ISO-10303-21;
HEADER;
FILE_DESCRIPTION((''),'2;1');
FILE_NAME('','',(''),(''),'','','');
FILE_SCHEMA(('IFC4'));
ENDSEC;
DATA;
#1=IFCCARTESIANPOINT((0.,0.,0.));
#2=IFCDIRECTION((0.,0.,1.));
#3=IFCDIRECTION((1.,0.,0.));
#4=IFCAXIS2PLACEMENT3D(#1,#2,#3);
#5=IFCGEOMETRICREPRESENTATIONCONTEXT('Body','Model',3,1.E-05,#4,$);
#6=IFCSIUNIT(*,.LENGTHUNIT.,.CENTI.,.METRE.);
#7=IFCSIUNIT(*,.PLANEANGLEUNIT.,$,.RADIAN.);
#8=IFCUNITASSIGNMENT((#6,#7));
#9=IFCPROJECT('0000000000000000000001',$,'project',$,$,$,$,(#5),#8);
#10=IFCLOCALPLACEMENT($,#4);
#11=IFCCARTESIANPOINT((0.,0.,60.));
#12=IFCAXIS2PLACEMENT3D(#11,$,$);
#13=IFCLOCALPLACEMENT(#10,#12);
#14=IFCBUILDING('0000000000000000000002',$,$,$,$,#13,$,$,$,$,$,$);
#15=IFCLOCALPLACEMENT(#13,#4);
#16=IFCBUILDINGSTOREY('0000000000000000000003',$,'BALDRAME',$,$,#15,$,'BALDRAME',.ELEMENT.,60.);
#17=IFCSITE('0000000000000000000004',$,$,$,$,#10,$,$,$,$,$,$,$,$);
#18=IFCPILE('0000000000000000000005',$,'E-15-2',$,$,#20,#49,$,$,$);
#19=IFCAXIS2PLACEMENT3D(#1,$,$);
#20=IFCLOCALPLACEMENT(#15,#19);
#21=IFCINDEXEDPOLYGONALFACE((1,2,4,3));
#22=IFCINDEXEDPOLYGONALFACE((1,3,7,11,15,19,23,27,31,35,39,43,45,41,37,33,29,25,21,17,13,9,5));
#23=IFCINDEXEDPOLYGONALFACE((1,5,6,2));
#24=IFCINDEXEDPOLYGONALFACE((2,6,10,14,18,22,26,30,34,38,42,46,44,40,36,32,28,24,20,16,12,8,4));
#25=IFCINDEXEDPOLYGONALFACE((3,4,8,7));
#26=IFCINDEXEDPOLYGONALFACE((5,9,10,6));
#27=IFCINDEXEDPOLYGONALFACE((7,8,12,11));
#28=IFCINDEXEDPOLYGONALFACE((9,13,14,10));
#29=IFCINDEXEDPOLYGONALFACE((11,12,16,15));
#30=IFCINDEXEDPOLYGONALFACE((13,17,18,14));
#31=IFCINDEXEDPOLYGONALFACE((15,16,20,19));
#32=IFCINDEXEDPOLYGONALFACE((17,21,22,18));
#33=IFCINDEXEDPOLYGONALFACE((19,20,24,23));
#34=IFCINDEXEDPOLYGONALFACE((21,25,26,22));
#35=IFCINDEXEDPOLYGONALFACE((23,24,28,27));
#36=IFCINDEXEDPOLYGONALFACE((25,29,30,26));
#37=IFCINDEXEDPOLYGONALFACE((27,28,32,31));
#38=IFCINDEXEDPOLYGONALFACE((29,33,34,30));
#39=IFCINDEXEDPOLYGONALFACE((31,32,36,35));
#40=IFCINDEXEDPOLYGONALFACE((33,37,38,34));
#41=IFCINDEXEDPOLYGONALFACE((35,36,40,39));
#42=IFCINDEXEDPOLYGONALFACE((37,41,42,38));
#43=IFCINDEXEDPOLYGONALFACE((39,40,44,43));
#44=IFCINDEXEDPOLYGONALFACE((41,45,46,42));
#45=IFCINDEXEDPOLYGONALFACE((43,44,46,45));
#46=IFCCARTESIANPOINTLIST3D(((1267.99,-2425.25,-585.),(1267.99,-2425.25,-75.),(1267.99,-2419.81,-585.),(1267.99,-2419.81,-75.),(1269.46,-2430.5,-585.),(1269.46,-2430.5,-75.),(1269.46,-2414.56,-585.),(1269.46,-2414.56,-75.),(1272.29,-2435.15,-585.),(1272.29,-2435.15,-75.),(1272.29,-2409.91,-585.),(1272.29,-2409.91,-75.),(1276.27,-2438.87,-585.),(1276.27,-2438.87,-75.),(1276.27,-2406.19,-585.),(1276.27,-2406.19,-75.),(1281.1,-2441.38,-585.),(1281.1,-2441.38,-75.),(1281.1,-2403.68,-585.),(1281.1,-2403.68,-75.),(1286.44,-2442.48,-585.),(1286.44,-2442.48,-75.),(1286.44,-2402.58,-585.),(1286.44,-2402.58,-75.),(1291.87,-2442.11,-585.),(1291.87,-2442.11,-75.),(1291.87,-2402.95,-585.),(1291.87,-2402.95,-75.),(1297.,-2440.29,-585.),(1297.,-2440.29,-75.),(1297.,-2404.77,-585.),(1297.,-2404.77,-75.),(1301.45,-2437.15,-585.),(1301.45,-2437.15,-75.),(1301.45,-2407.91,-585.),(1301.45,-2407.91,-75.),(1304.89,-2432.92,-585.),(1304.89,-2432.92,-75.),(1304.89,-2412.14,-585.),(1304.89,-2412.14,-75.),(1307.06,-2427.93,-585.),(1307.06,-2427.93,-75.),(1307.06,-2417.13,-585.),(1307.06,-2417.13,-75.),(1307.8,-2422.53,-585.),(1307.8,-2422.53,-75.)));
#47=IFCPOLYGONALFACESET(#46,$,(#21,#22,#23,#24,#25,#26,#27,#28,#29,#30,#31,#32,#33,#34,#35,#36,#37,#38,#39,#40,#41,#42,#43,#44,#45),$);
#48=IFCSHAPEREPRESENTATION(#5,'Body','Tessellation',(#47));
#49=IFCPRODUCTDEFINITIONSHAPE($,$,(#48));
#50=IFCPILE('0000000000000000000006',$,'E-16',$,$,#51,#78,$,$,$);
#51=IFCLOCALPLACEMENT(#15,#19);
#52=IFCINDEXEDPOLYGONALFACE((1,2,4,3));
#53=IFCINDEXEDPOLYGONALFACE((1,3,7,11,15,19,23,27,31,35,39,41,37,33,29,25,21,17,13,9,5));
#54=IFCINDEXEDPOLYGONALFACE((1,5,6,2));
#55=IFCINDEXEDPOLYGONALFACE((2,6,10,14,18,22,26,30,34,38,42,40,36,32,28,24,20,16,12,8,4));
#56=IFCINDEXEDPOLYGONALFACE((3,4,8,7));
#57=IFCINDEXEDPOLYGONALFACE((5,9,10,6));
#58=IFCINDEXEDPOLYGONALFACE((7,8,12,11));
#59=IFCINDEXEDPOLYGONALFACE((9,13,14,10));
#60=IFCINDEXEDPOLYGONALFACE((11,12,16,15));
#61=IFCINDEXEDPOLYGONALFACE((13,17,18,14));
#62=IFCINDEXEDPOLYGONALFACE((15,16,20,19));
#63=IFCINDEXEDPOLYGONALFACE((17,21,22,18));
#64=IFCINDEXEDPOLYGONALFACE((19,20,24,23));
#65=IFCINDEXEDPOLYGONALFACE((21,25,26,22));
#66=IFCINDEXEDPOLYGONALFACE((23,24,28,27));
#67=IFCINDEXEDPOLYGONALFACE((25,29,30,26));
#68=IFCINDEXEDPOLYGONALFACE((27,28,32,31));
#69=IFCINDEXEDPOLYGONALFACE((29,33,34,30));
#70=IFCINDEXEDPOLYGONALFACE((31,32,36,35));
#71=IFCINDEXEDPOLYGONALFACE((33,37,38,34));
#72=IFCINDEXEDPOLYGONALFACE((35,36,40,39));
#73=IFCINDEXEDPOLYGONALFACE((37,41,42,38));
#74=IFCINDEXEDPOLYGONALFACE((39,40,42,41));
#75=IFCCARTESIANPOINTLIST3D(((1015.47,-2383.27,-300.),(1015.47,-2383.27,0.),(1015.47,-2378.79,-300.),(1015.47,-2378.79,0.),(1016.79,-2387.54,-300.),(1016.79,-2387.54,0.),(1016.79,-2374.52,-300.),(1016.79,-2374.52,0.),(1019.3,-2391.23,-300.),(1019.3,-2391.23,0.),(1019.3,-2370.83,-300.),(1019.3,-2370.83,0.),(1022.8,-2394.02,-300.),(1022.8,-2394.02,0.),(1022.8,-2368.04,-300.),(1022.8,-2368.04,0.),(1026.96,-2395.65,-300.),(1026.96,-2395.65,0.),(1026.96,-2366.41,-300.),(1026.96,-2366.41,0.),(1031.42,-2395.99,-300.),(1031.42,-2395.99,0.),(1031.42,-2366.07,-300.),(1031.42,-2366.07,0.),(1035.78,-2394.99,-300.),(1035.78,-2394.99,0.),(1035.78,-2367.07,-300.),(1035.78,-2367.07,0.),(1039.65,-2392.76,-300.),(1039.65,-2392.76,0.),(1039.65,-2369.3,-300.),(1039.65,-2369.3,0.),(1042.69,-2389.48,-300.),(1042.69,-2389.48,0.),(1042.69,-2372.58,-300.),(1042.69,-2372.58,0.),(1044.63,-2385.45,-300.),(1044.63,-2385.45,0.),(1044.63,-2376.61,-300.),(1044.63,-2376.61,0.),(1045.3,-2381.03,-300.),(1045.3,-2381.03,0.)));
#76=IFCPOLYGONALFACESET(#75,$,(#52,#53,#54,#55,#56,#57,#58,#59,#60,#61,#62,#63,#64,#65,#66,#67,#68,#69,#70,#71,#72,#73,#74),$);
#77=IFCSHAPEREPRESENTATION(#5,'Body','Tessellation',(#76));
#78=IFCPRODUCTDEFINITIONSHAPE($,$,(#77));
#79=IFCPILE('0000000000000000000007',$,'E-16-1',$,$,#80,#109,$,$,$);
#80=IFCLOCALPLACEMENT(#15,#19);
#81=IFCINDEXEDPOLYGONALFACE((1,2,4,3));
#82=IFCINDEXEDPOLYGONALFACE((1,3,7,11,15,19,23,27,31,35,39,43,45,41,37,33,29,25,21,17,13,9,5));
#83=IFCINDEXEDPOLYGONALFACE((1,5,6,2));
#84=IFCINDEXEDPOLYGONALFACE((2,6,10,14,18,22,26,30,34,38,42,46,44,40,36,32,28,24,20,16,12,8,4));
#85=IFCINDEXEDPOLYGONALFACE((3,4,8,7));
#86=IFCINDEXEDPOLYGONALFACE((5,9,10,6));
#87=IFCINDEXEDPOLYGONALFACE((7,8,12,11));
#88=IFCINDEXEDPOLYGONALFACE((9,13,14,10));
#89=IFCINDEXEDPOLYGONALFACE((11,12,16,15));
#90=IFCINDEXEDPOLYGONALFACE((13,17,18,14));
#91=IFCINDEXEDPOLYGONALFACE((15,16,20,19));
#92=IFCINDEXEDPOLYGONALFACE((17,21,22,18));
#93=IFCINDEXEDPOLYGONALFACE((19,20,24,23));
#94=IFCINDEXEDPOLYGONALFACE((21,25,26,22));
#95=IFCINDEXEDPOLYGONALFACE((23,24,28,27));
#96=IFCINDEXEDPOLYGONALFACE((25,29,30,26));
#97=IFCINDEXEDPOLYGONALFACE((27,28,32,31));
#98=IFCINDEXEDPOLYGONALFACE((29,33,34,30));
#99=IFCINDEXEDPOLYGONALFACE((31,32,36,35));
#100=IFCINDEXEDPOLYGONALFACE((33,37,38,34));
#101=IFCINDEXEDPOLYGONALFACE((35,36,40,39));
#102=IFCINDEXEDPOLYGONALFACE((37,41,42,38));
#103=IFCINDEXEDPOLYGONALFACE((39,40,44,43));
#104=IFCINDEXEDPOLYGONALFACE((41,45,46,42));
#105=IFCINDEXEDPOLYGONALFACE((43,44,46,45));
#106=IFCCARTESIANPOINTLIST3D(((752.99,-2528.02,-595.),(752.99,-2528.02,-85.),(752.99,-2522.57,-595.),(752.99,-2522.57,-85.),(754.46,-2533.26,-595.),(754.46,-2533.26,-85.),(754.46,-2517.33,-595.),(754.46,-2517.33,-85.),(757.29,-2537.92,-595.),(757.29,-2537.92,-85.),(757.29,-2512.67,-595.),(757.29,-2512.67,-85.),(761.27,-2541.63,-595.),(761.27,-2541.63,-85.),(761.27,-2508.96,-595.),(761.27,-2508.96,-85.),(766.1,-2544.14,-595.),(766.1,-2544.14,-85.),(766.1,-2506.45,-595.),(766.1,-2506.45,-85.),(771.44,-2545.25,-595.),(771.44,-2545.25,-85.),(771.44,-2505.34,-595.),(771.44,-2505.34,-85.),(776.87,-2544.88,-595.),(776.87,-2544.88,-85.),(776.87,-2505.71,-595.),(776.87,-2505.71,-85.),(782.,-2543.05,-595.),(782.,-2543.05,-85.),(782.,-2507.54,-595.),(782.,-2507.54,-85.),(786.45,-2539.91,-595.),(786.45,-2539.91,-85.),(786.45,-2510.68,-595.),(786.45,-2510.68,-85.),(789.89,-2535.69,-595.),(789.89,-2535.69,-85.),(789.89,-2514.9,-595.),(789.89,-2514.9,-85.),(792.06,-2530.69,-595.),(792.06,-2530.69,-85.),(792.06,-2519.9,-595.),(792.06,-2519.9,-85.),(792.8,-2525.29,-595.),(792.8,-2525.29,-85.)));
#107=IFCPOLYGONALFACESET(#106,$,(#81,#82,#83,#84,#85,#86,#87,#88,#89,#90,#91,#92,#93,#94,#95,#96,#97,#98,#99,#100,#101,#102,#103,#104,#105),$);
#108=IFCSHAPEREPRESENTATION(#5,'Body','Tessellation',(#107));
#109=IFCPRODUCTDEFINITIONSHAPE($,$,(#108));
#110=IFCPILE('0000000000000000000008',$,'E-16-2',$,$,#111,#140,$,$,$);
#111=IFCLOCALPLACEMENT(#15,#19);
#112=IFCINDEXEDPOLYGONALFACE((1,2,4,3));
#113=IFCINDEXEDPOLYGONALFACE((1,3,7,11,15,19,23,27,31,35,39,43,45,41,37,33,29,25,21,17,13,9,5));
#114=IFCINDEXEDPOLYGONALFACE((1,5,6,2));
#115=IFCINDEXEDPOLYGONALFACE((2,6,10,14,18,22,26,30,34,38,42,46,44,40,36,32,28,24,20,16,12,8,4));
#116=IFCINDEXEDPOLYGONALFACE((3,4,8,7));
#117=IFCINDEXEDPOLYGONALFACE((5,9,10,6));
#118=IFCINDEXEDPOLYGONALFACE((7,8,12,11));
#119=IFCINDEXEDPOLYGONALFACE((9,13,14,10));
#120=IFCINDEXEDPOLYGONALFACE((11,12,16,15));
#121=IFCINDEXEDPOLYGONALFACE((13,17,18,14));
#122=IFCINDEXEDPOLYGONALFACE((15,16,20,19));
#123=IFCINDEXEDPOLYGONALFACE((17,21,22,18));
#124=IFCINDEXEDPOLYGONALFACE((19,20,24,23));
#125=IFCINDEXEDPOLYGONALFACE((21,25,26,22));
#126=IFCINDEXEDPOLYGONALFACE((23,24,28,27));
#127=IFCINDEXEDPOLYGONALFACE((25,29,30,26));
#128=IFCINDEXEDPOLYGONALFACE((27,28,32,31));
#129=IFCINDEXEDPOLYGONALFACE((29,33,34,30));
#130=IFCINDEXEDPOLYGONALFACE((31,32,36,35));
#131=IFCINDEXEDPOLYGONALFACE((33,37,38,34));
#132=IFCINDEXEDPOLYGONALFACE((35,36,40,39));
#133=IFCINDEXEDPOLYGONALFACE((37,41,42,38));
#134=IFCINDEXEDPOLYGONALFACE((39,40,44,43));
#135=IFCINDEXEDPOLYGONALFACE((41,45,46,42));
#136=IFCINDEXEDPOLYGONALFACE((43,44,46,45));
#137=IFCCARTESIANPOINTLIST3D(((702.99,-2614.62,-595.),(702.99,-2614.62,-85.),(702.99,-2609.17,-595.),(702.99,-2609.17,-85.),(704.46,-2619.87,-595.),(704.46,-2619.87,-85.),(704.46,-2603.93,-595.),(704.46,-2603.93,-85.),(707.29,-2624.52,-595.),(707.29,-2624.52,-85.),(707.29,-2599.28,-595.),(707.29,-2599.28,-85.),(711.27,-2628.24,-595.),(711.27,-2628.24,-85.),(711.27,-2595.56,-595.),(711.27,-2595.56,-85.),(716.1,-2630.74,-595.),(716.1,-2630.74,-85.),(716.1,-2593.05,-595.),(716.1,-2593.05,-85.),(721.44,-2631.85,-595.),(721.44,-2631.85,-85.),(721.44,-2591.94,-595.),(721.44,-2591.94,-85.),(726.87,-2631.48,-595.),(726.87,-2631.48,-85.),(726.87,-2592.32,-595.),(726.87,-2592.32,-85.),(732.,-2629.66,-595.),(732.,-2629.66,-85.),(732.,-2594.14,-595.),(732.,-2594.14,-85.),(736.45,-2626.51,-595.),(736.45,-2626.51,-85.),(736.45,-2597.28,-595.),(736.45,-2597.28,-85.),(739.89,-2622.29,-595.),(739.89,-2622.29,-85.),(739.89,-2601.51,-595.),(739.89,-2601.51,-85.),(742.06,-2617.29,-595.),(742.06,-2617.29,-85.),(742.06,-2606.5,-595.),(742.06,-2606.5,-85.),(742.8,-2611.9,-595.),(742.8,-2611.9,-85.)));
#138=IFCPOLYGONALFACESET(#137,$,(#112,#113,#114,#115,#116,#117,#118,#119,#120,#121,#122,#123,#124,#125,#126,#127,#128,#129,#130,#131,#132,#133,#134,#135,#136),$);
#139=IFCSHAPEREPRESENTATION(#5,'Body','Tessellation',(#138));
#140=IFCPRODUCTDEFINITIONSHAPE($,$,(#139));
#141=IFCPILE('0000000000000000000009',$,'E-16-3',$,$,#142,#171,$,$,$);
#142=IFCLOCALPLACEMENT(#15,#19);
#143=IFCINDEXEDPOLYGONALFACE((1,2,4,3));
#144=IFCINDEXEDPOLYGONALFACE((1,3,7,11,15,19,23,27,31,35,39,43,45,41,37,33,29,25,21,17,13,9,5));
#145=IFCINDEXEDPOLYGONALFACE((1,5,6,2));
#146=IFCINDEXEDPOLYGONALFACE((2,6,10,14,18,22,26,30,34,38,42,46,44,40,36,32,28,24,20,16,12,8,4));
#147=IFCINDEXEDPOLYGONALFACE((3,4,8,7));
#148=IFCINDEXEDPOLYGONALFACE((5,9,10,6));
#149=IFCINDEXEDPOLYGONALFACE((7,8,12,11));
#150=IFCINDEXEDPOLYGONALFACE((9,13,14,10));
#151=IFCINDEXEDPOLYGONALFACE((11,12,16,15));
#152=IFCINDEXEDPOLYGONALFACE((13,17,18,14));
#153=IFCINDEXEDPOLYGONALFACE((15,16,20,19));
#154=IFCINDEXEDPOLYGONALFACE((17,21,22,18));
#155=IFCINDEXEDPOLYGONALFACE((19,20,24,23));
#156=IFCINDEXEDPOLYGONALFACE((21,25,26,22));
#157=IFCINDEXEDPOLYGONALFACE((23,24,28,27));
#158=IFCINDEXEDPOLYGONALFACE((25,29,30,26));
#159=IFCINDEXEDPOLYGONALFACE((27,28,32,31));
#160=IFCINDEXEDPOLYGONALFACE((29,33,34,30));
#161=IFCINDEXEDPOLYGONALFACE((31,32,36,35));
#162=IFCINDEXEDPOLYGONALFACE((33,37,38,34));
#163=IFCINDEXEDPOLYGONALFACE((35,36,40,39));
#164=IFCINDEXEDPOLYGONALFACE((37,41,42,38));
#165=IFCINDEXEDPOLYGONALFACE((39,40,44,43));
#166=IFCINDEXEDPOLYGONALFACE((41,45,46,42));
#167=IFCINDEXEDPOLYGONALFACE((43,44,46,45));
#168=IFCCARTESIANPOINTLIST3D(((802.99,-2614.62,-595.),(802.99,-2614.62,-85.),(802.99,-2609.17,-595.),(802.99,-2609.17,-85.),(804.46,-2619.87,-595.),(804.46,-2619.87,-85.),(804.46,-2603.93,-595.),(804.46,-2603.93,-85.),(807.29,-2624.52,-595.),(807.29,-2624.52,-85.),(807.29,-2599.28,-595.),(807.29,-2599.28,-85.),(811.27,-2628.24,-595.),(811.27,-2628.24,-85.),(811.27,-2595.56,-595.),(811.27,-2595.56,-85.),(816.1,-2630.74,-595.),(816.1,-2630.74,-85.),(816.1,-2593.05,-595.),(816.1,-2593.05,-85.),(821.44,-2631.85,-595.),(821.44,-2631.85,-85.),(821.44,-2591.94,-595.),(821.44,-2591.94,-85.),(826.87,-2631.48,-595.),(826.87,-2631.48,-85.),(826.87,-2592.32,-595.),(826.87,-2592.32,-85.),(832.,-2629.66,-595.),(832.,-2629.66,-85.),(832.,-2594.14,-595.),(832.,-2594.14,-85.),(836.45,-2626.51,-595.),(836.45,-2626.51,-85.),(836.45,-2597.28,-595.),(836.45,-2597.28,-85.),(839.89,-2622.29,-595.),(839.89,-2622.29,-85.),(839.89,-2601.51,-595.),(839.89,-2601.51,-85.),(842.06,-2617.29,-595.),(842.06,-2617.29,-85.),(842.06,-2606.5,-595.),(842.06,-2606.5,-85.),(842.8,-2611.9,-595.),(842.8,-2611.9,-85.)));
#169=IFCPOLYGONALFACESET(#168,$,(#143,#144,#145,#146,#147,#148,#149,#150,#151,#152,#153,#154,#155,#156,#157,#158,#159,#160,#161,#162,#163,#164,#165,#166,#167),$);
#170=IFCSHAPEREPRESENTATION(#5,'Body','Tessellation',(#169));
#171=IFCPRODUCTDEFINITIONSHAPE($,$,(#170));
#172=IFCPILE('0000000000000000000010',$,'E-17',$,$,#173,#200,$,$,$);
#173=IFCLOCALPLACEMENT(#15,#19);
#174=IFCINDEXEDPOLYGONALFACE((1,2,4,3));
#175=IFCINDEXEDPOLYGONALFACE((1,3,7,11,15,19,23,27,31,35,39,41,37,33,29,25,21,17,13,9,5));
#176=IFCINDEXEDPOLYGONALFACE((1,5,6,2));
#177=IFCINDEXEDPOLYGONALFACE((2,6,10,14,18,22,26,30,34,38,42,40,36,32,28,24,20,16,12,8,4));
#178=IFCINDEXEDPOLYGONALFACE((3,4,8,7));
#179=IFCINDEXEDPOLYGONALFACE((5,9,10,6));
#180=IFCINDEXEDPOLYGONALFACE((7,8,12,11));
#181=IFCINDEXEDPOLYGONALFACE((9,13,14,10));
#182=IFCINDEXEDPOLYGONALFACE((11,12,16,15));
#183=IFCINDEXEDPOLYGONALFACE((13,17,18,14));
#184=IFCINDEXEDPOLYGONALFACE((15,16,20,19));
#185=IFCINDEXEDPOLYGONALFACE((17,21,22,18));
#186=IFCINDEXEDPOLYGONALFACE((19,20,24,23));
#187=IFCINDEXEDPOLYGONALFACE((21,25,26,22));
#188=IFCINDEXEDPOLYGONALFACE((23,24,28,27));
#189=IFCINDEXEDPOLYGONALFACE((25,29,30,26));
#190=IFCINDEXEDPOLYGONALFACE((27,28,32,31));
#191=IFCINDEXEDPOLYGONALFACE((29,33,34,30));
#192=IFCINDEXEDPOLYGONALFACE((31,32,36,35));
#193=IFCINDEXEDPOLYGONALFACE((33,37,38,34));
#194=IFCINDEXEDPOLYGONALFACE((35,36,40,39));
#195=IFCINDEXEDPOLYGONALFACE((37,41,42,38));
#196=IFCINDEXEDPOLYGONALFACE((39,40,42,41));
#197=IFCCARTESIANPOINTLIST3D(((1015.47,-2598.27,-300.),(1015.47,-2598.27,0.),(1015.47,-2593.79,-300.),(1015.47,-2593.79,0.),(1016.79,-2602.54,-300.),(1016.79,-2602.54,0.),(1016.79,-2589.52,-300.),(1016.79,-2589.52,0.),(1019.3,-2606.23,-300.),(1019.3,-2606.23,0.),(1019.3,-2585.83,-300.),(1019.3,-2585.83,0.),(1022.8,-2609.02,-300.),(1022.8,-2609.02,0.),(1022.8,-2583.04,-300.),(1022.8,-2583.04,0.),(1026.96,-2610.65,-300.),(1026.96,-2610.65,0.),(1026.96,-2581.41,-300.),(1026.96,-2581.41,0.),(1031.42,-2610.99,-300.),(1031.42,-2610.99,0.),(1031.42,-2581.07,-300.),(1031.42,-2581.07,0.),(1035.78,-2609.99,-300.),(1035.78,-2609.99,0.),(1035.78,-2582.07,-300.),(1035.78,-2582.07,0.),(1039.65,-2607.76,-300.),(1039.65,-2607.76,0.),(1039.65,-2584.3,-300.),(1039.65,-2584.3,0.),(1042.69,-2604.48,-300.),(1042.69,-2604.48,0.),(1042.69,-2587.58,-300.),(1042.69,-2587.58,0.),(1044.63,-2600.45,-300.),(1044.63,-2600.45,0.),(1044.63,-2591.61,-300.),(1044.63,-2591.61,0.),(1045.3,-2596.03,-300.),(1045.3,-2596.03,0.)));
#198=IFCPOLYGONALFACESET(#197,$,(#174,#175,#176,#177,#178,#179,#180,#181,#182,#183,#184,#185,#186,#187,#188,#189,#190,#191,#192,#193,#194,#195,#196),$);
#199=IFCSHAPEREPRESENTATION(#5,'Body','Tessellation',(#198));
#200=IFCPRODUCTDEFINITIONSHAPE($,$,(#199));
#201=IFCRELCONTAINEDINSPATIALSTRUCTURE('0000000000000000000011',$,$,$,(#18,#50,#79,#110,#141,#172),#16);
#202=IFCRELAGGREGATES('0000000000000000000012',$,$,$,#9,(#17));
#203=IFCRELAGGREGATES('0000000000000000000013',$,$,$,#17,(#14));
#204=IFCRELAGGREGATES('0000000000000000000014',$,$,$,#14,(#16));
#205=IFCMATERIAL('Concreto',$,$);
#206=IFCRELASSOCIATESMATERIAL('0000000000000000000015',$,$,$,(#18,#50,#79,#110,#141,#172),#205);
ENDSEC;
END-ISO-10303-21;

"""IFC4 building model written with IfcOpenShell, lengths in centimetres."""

from ifc_helpers import new_model, si_unit, frame, origin_with_axes, origin_2d_with_axis, place, context, project, spatial, circle, extrude, material, element, save


model = new_model("IFC4")

# Units and contexts
model_context = context("Model", 3, precision=1e-05, world=origin_with_axes(), identifier="Body")
ifc_project = project(units=[si_unit("LENGTHUNIT", "METRE", prefix="CENTI"), si_unit("PLANEANGLEUNIT", "RADIAN")], contexts=[model_context])

# Site, building, storey
site_placement = place(None, origin_with_axes())
site = spatial("IfcSite", under=ifc_project, at=site_placement)
building_placement = place(site_placement, frame((0.0, 0.0, 60.0)))
building = spatial("IfcBuilding", under=site, at=building_placement)
storey_placement = place(building_placement, origin_with_axes())
storey = spatial("IfcBuildingStorey", under=building, at=storey_placement, Name="BALDRAME", LongName="BALDRAME", CompositionType="ELEMENT", Elevation=60.0)

# Piles
ifc_material = material(Name="Concreto")
for number, where, z_axis, x_axis, name in (
    (1, (1287.8, -2422.53, -75.0), (0.0, 0.0, 1.0), (1.0, 0.0, 0.0), "E-15-2"),
):
    element("IfcPile", number, at=place(storey_placement, frame(where, z_axis=z_axis, x_axis=x_axis)), inside=storey, material=ifc_material, Name=name, context=model_context, shape_type="SweptSolid", body=[
        extrude(circle(Radius=20.0, at=origin_2d_with_axis()), frame((0.0, 0.0, -510.0), z_axis=(0.0, 0.0, 1.0), x_axis=(1.0, 0.0, 0.0)), (0.0, 0.0, 1.0), 510.0),
    ])
pile_1_placement = place(storey_placement, frame((1030.3, -2381.03, 0.0), z_axis=(0.0, 0.0, 1.0), x_axis=(1.0, 0.0, 0.0)))
element("IfcPile", 2, at=pile_1_placement, inside=storey, material=ifc_material, Name="E-16", context=model_context, shape_type="SolidModel", body=[
    extrude(circle(Radius=15.0, at=origin_2d_with_axis()), frame((0.0, 0.0, -300.0), z_axis=(0.0, 0.0, 1.0), x_axis=(1.0, 0.0, 0.0)), (0.0, 0.0, 1.0), 300.0),
])
for number, where, z_axis, x_axis, name in (
    (3, (772.8, -2525.29, -85.0), (0.0, 0.0, 1.0), (1.0, 0.0, 0.0), "E-16-1"),
    (4, (722.8, -2611.9, -85.0), (0.0, 0.0, 1.0), (1.0, 0.0, 0.0), "E-16-2"),
    (5, (822.8, -2611.9, -85.0), (0.0, 0.0, 1.0), (1.0, 0.0, 0.0), "E-16-3"),
):
    element("IfcPile", number, at=place(storey_placement, frame(where, z_axis=z_axis, x_axis=x_axis)), inside=storey, material=ifc_material, Name=name, context=model_context, shape_type="SweptSolid", body=[
        extrude(circle(Radius=20.0, at=origin_2d_with_axis()), frame((0.0, 0.0, -510.0), z_axis=(0.0, 0.0, 1.0), x_axis=(1.0, 0.0, 0.0)), (0.0, 0.0, 1.0), 510.0),
    ])
pile_2_placement = place(storey_placement, frame((1030.3, -2596.03, 0.0), z_axis=(0.0, 0.0, 1.0), x_axis=(1.0, 0.0, 0.0)))
element("IfcPile", 6, at=pile_2_placement, inside=storey, material=ifc_material, Name="E-17", context=model_context, shape_type="SolidModel", body=[
    extrude(circle(Radius=15.0, at=origin_2d_with_axis()), frame((0.0, 0.0, -300.0), z_axis=(0.0, 0.0, 1.0), x_axis=(1.0, 0.0, 0.0)), (0.0, 0.0, 1.0), 300.0),
])

save(model, "model.ifc")
